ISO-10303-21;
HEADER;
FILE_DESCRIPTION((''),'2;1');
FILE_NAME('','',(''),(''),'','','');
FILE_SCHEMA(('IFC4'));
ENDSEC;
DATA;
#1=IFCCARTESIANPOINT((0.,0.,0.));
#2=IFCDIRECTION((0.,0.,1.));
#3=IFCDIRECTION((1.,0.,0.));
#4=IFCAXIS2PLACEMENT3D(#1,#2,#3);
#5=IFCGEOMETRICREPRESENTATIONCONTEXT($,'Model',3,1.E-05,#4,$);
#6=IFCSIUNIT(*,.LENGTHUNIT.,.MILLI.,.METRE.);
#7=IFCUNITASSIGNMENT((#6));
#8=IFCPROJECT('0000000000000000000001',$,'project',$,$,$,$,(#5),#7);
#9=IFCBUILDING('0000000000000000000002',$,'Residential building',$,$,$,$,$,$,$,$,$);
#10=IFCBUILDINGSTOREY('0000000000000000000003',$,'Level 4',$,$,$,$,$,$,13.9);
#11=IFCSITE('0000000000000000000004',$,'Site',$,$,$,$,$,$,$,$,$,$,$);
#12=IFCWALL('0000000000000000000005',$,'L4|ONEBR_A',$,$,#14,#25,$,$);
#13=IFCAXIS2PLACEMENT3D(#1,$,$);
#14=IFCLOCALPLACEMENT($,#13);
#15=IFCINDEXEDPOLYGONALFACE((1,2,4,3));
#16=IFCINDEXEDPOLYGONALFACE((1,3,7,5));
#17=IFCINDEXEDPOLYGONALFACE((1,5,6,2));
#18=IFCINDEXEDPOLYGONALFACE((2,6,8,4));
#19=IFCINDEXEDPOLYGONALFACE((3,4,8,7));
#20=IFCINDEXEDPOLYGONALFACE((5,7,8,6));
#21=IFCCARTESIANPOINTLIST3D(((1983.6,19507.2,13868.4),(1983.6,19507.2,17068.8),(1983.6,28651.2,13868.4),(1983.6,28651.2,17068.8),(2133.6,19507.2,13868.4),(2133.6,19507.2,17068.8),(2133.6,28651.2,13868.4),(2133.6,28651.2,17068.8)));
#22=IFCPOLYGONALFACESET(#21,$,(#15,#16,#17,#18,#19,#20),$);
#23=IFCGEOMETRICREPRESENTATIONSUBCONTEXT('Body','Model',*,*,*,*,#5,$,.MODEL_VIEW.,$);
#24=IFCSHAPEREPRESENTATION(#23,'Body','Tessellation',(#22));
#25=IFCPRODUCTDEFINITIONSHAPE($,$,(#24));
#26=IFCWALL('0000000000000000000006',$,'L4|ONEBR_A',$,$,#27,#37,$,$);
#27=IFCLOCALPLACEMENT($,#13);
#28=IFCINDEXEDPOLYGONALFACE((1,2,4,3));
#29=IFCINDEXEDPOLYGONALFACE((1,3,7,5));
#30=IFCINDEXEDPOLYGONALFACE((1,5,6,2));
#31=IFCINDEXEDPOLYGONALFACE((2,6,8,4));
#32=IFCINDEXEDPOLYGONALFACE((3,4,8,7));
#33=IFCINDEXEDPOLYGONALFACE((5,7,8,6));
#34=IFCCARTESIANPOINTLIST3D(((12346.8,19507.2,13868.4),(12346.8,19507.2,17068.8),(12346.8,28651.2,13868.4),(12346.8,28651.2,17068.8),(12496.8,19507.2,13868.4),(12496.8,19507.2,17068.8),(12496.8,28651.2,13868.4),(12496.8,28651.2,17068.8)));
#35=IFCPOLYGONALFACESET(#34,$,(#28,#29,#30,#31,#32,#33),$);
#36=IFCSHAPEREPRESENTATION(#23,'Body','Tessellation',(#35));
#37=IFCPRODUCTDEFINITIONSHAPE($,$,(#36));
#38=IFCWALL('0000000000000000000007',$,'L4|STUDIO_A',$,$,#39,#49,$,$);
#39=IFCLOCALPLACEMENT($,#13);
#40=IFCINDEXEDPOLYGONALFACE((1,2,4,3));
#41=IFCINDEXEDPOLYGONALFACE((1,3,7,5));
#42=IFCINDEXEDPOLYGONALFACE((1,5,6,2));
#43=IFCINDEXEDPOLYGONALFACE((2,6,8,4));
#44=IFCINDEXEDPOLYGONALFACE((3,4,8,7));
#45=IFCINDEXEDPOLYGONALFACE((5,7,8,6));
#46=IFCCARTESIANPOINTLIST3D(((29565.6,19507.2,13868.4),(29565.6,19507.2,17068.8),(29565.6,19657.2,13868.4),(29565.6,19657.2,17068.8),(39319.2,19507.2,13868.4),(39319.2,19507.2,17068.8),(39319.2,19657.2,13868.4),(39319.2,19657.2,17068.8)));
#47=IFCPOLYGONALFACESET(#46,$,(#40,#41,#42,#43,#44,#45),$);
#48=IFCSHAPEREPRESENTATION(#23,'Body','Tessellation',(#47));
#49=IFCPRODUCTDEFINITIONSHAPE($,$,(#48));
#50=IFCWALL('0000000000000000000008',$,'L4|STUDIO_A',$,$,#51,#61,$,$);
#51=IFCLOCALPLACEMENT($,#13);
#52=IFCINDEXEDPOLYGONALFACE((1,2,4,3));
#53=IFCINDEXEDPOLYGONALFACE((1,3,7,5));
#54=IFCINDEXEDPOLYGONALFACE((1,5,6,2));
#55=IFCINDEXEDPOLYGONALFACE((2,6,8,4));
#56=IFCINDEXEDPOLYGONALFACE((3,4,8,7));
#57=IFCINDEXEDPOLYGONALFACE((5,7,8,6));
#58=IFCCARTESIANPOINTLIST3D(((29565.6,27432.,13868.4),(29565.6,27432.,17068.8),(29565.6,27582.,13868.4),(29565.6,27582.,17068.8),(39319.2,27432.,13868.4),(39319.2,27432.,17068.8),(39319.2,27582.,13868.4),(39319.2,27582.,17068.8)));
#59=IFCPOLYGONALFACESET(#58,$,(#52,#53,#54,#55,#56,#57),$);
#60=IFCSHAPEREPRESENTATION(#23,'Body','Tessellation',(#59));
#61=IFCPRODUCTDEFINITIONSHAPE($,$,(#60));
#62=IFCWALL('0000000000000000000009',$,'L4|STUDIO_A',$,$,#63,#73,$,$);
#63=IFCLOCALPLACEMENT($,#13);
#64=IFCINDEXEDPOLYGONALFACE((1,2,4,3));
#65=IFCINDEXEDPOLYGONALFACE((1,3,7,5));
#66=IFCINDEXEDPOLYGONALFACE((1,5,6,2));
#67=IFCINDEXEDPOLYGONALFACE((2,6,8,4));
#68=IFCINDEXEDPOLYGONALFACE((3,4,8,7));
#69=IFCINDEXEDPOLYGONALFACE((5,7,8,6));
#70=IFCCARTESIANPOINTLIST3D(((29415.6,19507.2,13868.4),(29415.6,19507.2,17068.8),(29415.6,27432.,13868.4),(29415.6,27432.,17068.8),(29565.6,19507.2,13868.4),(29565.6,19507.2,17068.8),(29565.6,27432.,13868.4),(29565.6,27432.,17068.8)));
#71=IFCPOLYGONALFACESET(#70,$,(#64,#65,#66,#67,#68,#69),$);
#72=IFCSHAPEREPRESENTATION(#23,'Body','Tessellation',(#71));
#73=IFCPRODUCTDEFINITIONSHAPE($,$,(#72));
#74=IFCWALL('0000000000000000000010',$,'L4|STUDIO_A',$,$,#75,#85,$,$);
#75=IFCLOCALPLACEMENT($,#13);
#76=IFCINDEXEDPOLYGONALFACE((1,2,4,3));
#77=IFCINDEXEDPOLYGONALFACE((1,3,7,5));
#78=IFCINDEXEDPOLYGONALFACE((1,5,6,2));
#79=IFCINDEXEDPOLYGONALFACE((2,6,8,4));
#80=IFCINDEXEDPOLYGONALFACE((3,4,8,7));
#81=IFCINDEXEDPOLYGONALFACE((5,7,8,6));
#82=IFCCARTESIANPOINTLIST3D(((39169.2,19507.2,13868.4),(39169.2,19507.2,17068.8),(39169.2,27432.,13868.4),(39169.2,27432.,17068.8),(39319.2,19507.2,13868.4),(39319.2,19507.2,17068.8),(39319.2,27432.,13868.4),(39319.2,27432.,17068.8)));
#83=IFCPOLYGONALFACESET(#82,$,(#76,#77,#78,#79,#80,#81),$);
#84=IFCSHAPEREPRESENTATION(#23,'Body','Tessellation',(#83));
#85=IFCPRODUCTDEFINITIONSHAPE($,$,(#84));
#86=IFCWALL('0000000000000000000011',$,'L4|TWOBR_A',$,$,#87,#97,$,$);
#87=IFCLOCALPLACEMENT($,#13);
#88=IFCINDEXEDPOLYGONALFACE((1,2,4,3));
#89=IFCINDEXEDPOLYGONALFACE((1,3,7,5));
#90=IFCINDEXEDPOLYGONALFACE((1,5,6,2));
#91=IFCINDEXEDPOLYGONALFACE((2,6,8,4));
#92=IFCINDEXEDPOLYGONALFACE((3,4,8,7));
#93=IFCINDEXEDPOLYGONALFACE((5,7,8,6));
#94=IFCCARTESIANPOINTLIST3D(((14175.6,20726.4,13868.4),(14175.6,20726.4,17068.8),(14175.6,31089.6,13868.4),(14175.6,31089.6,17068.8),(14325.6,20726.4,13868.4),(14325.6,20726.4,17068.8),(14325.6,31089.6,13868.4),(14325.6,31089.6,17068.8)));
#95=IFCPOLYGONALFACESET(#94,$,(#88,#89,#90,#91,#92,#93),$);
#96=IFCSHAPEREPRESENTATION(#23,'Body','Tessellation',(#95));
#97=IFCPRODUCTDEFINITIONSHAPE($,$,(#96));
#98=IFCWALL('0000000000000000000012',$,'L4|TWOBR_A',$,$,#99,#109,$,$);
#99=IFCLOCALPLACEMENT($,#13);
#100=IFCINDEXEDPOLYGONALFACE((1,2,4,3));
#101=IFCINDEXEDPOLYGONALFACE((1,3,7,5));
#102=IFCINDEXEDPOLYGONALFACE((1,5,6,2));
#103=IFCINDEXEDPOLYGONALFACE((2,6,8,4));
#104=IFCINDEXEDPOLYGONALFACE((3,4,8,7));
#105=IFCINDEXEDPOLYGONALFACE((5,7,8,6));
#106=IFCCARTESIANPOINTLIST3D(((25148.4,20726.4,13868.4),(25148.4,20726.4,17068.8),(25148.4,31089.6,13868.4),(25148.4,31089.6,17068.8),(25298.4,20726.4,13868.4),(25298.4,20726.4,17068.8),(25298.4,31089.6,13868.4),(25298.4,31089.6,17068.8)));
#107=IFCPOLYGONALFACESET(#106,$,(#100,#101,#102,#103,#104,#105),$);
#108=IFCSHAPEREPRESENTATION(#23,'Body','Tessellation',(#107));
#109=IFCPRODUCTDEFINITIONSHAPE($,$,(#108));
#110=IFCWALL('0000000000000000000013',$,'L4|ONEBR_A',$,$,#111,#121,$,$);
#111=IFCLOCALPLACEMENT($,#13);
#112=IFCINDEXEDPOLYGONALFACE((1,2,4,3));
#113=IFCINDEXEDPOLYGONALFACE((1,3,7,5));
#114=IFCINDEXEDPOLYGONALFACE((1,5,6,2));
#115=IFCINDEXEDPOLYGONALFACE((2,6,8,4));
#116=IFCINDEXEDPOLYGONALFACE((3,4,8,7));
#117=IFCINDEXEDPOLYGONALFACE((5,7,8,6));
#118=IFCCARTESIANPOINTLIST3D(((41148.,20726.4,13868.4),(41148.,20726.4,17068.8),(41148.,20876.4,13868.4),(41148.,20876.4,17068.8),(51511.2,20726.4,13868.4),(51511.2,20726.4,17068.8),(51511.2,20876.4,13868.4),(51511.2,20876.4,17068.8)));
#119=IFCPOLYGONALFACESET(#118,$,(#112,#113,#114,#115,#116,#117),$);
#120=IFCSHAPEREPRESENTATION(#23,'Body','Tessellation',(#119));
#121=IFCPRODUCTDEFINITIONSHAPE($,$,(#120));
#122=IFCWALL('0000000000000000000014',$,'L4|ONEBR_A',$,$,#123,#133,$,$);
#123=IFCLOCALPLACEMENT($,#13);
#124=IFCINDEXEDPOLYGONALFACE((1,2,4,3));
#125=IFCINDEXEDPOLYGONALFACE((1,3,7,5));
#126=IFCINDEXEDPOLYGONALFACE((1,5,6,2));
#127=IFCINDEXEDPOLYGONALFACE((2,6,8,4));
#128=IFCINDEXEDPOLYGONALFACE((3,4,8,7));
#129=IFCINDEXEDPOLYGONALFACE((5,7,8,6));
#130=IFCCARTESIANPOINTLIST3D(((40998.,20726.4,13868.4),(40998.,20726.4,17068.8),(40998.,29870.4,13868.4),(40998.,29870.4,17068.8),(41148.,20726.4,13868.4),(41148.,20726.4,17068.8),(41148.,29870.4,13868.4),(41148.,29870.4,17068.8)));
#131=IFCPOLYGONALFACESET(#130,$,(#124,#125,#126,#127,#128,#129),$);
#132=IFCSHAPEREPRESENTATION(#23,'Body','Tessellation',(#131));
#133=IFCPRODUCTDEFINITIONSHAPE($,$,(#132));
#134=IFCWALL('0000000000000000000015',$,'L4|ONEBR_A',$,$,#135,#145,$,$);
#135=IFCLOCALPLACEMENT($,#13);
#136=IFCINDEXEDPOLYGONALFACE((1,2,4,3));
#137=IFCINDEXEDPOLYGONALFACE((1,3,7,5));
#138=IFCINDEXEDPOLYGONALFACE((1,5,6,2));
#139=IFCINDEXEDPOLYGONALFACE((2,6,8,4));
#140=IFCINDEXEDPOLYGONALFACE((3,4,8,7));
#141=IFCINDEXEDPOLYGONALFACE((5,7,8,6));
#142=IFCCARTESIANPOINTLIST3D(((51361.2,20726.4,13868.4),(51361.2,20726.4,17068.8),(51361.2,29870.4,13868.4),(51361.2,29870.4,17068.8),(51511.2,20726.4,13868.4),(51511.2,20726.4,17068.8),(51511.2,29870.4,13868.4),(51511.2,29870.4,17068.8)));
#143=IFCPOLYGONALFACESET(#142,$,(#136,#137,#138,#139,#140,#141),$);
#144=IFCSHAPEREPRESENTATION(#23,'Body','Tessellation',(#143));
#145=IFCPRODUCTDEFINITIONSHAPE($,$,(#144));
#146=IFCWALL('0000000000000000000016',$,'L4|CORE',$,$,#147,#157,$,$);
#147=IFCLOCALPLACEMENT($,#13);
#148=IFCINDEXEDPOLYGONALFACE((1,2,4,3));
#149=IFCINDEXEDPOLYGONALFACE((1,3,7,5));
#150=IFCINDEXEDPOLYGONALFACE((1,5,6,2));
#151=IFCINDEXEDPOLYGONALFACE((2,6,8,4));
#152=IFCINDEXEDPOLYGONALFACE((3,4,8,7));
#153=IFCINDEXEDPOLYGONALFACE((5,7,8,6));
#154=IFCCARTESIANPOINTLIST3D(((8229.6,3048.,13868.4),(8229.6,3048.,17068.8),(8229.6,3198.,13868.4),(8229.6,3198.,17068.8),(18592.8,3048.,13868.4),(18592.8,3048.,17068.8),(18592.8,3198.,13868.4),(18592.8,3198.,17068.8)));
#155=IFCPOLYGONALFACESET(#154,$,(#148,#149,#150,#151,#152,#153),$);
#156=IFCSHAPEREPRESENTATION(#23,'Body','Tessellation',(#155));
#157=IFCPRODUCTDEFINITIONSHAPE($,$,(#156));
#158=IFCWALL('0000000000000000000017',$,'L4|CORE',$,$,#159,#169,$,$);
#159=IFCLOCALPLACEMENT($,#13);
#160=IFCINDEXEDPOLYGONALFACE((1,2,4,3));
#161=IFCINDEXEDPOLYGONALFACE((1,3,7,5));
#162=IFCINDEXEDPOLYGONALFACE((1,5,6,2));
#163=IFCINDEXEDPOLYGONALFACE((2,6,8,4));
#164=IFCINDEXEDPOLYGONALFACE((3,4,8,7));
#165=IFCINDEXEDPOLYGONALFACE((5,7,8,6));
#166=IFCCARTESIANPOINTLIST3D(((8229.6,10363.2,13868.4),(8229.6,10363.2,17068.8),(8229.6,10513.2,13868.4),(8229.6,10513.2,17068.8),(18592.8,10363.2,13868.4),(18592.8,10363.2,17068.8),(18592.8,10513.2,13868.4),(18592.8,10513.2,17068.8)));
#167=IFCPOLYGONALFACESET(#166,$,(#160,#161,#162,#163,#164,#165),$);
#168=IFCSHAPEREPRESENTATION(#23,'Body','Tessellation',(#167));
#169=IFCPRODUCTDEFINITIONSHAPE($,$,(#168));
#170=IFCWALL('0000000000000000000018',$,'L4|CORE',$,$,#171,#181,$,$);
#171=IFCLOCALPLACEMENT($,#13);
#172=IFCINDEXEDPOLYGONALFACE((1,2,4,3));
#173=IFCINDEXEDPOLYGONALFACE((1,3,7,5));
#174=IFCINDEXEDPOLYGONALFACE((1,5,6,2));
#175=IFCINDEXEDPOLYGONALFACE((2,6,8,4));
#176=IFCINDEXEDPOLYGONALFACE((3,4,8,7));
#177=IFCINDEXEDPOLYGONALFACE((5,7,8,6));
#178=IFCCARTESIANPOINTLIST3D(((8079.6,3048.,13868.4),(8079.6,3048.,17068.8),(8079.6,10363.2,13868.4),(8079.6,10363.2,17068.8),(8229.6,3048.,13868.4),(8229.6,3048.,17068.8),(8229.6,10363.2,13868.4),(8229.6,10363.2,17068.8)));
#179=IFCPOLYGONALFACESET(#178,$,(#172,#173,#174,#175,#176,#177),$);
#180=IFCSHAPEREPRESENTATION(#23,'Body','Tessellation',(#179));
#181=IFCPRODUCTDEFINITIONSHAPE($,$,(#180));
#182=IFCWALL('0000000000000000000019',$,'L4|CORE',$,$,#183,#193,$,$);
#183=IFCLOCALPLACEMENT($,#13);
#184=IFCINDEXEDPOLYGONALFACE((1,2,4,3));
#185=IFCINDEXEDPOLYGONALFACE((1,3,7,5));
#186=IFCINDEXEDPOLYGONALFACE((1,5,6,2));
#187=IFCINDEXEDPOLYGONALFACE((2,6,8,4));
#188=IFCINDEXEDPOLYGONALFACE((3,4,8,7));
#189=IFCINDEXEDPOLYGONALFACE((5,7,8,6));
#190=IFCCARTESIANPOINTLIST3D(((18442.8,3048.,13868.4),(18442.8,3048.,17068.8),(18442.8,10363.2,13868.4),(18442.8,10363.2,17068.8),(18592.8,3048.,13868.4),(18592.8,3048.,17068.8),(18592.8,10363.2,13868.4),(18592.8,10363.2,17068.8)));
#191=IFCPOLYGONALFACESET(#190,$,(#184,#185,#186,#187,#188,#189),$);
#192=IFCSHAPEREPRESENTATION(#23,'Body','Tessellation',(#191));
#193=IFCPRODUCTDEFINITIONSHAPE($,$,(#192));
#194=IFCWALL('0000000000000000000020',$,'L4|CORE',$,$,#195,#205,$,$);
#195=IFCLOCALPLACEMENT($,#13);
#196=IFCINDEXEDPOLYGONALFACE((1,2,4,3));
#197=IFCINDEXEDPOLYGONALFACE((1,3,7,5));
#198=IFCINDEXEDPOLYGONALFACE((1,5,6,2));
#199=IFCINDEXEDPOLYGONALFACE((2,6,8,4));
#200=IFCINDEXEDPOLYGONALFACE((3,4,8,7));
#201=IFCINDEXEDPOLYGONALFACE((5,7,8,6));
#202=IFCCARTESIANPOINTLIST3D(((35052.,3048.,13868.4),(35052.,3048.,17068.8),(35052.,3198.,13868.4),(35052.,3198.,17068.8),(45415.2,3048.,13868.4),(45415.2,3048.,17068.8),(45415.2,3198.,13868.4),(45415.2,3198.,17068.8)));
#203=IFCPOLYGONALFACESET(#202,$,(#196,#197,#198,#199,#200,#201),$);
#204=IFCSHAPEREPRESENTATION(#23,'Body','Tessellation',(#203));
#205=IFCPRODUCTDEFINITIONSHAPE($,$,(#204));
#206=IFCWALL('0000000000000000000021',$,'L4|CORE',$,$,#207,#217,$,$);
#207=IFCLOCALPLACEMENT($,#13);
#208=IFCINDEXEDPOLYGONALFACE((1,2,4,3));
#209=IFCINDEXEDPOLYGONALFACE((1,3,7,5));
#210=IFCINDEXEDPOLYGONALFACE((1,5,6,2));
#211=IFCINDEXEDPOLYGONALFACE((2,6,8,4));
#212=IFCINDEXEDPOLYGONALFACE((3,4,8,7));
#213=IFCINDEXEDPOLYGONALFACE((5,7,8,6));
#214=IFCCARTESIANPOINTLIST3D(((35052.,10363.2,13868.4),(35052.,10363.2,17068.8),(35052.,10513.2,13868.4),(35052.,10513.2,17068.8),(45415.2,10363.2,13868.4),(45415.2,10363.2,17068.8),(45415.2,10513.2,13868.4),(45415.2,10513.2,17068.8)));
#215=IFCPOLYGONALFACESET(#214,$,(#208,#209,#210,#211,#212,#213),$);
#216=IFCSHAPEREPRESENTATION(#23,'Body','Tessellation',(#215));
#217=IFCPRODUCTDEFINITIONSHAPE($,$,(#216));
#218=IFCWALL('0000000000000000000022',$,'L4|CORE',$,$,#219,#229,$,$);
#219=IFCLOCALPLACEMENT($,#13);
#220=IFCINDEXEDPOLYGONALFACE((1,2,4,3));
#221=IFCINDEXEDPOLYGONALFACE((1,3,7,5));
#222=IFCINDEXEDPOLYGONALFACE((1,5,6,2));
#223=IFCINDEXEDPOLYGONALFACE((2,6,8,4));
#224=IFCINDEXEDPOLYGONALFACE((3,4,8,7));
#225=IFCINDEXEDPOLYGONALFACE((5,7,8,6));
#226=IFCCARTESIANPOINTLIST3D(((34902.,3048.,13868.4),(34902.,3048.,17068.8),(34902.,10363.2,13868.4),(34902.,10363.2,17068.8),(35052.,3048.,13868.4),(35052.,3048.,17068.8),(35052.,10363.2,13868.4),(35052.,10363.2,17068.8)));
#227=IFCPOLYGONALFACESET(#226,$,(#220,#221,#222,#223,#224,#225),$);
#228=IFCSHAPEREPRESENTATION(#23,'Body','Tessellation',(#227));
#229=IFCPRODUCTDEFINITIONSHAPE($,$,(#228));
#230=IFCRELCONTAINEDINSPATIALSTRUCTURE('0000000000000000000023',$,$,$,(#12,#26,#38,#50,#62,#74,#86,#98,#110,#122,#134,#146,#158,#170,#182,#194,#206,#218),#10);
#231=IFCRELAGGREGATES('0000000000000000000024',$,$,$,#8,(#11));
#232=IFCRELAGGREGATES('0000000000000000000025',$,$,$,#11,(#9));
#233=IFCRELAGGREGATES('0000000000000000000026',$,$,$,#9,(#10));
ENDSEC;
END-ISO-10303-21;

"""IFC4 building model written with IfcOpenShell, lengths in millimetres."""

from ifc_helpers import new_model, si_unit, frame, origin_with_axes, place, context, subcontext, project, spatial, indexed_curve, outline, extrude, element, save


model = new_model("IFC4")

# Units and contexts
model_context = context("Model", 3, precision=1e-05, world=origin_with_axes())
body_context = subcontext(model_context, "Body", "Model", "MODEL_VIEW")
ifc_project = project(units=[si_unit("LENGTHUNIT", "METRE", prefix="MILLI")], contexts=[model_context])

# Site, building, storey
site = spatial("IfcSite", under=ifc_project, Name="Site")
building = spatial("IfcBuilding", under=site, Name="Residential building")
storey = spatial("IfcBuildingStorey", under=building, Name="Level 4", Elevation=13.9)

# Walls
for number, where, z_axis, x_axis, name in (
    (1, (2133.6, 19507.2, 13868.4), (0.0, 0.0, 1.0), (0.0, 1.0, 0.0), "L4|ONEBR_A"),
    (2, (12496.8, 19507.2, 13868.4), (0.0, 0.0, 1.0), (0.0, 1.0, 0.0), "L4|ONEBR_A"),
):
    element("IfcWall", number, at=place(None, frame(where, z_axis=z_axis, x_axis=x_axis)), inside=storey, Name=name, context=body_context, shape_type="SweptSolid", body=[
        extrude(outline(indexed_curve([(0.0, 0.0), (0.0, 150.0), (9144.0, 150.0), (9144.0, 0.0), (0.0, 0.0)], self_intersect=False)), origin_with_axes(), (0.0, 0.0, 1.0), 3200.4),
    ])
for number, where, z_axis, x_axis, name in (
    (3, (29565.6, 19507.2, 13868.4), (0.0, 0.0, 1.0), (1.0, 0.0, 0.0), "L4|STUDIO_A"),
    (4, (29565.6, 27432.0, 13868.4), (0.0, 0.0, 1.0), (1.0, 0.0, 0.0), "L4|STUDIO_A"),
):
    element("IfcWall", number, at=place(None, frame(where, z_axis=z_axis, x_axis=x_axis)), inside=storey, Name=name, context=body_context, shape_type="SweptSolid", body=[
        extrude(outline(indexed_curve([(0.0, 0.0), (0.0, 150.0), (9753.6, 150.0), (9753.6, 0.0), (0.0, 0.0)], self_intersect=False)), origin_with_axes(), (0.0, 0.0, 1.0), 3200.4),
    ])
for number, where, z_axis, x_axis, name in (
    (5, (29565.6, 19507.2, 13868.4), (0.0, 0.0, 1.0), (0.0, 1.0, 0.0), "L4|STUDIO_A"),
    (6, (39319.2, 19507.2, 13868.4), (0.0, 0.0, 1.0), (0.0, 1.0, 0.0), "L4|STUDIO_A"),
):
    element("IfcWall", number, at=place(None, frame(where, z_axis=z_axis, x_axis=x_axis)), inside=storey, Name=name, context=body_context, shape_type="SweptSolid", body=[
        extrude(outline(indexed_curve([(0.0, 0.0), (0.0, 150.0), (7924.8, 150.0), (7924.8, 0.0), (0.0, 0.0)], self_intersect=False)), origin_with_axes(), (0.0, 0.0, 1.0), 3200.4),
    ])
for number, where, z_axis, x_axis, name in (
    (7, (14325.6, 20726.4, 13868.4), (0.0, 0.0, 1.0), (0.0, 1.0, 0.0), "L4|TWOBR_A"),
    (8, (25298.4, 20726.4, 13868.4), (0.0, 0.0, 1.0), (0.0, 1.0, 0.0), "L4|TWOBR_A"),
    (9, (41148.0, 20726.4, 13868.4), (0.0, 0.0, 1.0), (1.0, 0.0, 0.0), "L4|ONEBR_A"),
):
    element("IfcWall", number, at=place(None, frame(where, z_axis=z_axis, x_axis=x_axis)), inside=storey, Name=name, context=body_context, shape_type="SweptSolid", body=[
        extrude(outline(indexed_curve([(0.0, 0.0), (0.0, 150.0), (10363.2, 150.0), (10363.2, 0.0), (0.0, 0.0)], self_intersect=False)), origin_with_axes(), (0.0, 0.0, 1.0), 3200.4),
    ])
for number, where, z_axis, x_axis, name in (
    (10, (41148.0, 20726.4, 13868.4), (0.0, 0.0, 1.0), (0.0, 1.0, 0.0), "L4|ONEBR_A"),
    (11, (51511.2, 20726.4, 13868.4), (0.0, 0.0, 1.0), (0.0, 1.0, 0.0), "L4|ONEBR_A"),
):
    element("IfcWall", number, at=place(None, frame(where, z_axis=z_axis, x_axis=x_axis)), inside=storey, Name=name, context=body_context, shape_type="SweptSolid", body=[
        extrude(outline(indexed_curve([(0.0, 0.0), (0.0, 150.0), (9144.0, 150.0), (9144.0, 0.0), (0.0, 0.0)], self_intersect=False)), origin_with_axes(), (0.0, 0.0, 1.0), 3200.4),
    ])
for number, where, z_axis, x_axis, name in (
    (12, (8229.6, 3048.0, 13868.4), (0.0, 0.0, 1.0), (1.0, 0.0, 0.0), "L4|CORE"),
    (13, (8229.6, 10363.2, 13868.4), (0.0, 0.0, 1.0), (1.0, 0.0, 0.0), "L4|CORE"),
):
    element("IfcWall", number, at=place(None, frame(where, z_axis=z_axis, x_axis=x_axis)), inside=storey, Name=name, context=body_context, shape_type="SweptSolid", body=[
        extrude(outline(indexed_curve([(0.0, 0.0), (0.0, 150.0), (10363.2, 150.0), (10363.2, 0.0), (0.0, 0.0)], self_intersect=False)), origin_with_axes(), (0.0, 0.0, 1.0), 3200.4),
    ])
for number, where, z_axis, x_axis, name in (
    (14, (8229.6, 3048.0, 13868.4), (0.0, 0.0, 1.0), (0.0, 1.0, 0.0), "L4|CORE"),
    (15, (18592.8, 3048.0, 13868.4), (0.0, 0.0, 1.0), (0.0, 1.0, 0.0), "L4|CORE"),
):
    element("IfcWall", number, at=place(None, frame(where, z_axis=z_axis, x_axis=x_axis)), inside=storey, Name=name, context=body_context, shape_type="SweptSolid", body=[
        extrude(outline(indexed_curve([(0.0, 0.0), (0.0, 150.0), (7315.2, 150.0), (7315.2, 0.0), (0.0, 0.0)], self_intersect=False)), origin_with_axes(), (0.0, 0.0, 1.0), 3200.4),
    ])
for number, where, z_axis, x_axis, name in (
    (16, (35052.0, 3048.0, 13868.4), (0.0, 0.0, 1.0), (1.0, 0.0, 0.0), "L4|CORE"),
    (17, (35052.0, 10363.2, 13868.4), (0.0, 0.0, 1.0), (1.0, 0.0, 0.0), "L4|CORE"),
):
    element("IfcWall", number, at=place(None, frame(where, z_axis=z_axis, x_axis=x_axis)), inside=storey, Name=name, context=body_context, shape_type="SweptSolid", body=[
        extrude(outline(indexed_curve([(0.0, 0.0), (0.0, 150.0), (10363.2, 150.0), (10363.2, 0.0), (0.0, 0.0)], self_intersect=False)), origin_with_axes(), (0.0, 0.0, 1.0), 3200.4),
    ])
for number, where, z_axis, x_axis, name in (
    (18, (35052.0, 3048.0, 13868.4), (0.0, 0.0, 1.0), (0.0, 1.0, 0.0), "L4|CORE"),
):
    element("IfcWall", number, at=place(None, frame(where, z_axis=z_axis, x_axis=x_axis)), inside=storey, Name=name, context=body_context, shape_type="SweptSolid", body=[
        extrude(outline(indexed_curve([(0.0, 0.0), (0.0, 150.0), (7315.2, 150.0), (7315.2, 0.0), (0.0, 0.0)], self_intersect=False)), origin_with_axes(), (0.0, 0.0, 1.0), 3200.4),
    ])

save(model, "model.ifc")
